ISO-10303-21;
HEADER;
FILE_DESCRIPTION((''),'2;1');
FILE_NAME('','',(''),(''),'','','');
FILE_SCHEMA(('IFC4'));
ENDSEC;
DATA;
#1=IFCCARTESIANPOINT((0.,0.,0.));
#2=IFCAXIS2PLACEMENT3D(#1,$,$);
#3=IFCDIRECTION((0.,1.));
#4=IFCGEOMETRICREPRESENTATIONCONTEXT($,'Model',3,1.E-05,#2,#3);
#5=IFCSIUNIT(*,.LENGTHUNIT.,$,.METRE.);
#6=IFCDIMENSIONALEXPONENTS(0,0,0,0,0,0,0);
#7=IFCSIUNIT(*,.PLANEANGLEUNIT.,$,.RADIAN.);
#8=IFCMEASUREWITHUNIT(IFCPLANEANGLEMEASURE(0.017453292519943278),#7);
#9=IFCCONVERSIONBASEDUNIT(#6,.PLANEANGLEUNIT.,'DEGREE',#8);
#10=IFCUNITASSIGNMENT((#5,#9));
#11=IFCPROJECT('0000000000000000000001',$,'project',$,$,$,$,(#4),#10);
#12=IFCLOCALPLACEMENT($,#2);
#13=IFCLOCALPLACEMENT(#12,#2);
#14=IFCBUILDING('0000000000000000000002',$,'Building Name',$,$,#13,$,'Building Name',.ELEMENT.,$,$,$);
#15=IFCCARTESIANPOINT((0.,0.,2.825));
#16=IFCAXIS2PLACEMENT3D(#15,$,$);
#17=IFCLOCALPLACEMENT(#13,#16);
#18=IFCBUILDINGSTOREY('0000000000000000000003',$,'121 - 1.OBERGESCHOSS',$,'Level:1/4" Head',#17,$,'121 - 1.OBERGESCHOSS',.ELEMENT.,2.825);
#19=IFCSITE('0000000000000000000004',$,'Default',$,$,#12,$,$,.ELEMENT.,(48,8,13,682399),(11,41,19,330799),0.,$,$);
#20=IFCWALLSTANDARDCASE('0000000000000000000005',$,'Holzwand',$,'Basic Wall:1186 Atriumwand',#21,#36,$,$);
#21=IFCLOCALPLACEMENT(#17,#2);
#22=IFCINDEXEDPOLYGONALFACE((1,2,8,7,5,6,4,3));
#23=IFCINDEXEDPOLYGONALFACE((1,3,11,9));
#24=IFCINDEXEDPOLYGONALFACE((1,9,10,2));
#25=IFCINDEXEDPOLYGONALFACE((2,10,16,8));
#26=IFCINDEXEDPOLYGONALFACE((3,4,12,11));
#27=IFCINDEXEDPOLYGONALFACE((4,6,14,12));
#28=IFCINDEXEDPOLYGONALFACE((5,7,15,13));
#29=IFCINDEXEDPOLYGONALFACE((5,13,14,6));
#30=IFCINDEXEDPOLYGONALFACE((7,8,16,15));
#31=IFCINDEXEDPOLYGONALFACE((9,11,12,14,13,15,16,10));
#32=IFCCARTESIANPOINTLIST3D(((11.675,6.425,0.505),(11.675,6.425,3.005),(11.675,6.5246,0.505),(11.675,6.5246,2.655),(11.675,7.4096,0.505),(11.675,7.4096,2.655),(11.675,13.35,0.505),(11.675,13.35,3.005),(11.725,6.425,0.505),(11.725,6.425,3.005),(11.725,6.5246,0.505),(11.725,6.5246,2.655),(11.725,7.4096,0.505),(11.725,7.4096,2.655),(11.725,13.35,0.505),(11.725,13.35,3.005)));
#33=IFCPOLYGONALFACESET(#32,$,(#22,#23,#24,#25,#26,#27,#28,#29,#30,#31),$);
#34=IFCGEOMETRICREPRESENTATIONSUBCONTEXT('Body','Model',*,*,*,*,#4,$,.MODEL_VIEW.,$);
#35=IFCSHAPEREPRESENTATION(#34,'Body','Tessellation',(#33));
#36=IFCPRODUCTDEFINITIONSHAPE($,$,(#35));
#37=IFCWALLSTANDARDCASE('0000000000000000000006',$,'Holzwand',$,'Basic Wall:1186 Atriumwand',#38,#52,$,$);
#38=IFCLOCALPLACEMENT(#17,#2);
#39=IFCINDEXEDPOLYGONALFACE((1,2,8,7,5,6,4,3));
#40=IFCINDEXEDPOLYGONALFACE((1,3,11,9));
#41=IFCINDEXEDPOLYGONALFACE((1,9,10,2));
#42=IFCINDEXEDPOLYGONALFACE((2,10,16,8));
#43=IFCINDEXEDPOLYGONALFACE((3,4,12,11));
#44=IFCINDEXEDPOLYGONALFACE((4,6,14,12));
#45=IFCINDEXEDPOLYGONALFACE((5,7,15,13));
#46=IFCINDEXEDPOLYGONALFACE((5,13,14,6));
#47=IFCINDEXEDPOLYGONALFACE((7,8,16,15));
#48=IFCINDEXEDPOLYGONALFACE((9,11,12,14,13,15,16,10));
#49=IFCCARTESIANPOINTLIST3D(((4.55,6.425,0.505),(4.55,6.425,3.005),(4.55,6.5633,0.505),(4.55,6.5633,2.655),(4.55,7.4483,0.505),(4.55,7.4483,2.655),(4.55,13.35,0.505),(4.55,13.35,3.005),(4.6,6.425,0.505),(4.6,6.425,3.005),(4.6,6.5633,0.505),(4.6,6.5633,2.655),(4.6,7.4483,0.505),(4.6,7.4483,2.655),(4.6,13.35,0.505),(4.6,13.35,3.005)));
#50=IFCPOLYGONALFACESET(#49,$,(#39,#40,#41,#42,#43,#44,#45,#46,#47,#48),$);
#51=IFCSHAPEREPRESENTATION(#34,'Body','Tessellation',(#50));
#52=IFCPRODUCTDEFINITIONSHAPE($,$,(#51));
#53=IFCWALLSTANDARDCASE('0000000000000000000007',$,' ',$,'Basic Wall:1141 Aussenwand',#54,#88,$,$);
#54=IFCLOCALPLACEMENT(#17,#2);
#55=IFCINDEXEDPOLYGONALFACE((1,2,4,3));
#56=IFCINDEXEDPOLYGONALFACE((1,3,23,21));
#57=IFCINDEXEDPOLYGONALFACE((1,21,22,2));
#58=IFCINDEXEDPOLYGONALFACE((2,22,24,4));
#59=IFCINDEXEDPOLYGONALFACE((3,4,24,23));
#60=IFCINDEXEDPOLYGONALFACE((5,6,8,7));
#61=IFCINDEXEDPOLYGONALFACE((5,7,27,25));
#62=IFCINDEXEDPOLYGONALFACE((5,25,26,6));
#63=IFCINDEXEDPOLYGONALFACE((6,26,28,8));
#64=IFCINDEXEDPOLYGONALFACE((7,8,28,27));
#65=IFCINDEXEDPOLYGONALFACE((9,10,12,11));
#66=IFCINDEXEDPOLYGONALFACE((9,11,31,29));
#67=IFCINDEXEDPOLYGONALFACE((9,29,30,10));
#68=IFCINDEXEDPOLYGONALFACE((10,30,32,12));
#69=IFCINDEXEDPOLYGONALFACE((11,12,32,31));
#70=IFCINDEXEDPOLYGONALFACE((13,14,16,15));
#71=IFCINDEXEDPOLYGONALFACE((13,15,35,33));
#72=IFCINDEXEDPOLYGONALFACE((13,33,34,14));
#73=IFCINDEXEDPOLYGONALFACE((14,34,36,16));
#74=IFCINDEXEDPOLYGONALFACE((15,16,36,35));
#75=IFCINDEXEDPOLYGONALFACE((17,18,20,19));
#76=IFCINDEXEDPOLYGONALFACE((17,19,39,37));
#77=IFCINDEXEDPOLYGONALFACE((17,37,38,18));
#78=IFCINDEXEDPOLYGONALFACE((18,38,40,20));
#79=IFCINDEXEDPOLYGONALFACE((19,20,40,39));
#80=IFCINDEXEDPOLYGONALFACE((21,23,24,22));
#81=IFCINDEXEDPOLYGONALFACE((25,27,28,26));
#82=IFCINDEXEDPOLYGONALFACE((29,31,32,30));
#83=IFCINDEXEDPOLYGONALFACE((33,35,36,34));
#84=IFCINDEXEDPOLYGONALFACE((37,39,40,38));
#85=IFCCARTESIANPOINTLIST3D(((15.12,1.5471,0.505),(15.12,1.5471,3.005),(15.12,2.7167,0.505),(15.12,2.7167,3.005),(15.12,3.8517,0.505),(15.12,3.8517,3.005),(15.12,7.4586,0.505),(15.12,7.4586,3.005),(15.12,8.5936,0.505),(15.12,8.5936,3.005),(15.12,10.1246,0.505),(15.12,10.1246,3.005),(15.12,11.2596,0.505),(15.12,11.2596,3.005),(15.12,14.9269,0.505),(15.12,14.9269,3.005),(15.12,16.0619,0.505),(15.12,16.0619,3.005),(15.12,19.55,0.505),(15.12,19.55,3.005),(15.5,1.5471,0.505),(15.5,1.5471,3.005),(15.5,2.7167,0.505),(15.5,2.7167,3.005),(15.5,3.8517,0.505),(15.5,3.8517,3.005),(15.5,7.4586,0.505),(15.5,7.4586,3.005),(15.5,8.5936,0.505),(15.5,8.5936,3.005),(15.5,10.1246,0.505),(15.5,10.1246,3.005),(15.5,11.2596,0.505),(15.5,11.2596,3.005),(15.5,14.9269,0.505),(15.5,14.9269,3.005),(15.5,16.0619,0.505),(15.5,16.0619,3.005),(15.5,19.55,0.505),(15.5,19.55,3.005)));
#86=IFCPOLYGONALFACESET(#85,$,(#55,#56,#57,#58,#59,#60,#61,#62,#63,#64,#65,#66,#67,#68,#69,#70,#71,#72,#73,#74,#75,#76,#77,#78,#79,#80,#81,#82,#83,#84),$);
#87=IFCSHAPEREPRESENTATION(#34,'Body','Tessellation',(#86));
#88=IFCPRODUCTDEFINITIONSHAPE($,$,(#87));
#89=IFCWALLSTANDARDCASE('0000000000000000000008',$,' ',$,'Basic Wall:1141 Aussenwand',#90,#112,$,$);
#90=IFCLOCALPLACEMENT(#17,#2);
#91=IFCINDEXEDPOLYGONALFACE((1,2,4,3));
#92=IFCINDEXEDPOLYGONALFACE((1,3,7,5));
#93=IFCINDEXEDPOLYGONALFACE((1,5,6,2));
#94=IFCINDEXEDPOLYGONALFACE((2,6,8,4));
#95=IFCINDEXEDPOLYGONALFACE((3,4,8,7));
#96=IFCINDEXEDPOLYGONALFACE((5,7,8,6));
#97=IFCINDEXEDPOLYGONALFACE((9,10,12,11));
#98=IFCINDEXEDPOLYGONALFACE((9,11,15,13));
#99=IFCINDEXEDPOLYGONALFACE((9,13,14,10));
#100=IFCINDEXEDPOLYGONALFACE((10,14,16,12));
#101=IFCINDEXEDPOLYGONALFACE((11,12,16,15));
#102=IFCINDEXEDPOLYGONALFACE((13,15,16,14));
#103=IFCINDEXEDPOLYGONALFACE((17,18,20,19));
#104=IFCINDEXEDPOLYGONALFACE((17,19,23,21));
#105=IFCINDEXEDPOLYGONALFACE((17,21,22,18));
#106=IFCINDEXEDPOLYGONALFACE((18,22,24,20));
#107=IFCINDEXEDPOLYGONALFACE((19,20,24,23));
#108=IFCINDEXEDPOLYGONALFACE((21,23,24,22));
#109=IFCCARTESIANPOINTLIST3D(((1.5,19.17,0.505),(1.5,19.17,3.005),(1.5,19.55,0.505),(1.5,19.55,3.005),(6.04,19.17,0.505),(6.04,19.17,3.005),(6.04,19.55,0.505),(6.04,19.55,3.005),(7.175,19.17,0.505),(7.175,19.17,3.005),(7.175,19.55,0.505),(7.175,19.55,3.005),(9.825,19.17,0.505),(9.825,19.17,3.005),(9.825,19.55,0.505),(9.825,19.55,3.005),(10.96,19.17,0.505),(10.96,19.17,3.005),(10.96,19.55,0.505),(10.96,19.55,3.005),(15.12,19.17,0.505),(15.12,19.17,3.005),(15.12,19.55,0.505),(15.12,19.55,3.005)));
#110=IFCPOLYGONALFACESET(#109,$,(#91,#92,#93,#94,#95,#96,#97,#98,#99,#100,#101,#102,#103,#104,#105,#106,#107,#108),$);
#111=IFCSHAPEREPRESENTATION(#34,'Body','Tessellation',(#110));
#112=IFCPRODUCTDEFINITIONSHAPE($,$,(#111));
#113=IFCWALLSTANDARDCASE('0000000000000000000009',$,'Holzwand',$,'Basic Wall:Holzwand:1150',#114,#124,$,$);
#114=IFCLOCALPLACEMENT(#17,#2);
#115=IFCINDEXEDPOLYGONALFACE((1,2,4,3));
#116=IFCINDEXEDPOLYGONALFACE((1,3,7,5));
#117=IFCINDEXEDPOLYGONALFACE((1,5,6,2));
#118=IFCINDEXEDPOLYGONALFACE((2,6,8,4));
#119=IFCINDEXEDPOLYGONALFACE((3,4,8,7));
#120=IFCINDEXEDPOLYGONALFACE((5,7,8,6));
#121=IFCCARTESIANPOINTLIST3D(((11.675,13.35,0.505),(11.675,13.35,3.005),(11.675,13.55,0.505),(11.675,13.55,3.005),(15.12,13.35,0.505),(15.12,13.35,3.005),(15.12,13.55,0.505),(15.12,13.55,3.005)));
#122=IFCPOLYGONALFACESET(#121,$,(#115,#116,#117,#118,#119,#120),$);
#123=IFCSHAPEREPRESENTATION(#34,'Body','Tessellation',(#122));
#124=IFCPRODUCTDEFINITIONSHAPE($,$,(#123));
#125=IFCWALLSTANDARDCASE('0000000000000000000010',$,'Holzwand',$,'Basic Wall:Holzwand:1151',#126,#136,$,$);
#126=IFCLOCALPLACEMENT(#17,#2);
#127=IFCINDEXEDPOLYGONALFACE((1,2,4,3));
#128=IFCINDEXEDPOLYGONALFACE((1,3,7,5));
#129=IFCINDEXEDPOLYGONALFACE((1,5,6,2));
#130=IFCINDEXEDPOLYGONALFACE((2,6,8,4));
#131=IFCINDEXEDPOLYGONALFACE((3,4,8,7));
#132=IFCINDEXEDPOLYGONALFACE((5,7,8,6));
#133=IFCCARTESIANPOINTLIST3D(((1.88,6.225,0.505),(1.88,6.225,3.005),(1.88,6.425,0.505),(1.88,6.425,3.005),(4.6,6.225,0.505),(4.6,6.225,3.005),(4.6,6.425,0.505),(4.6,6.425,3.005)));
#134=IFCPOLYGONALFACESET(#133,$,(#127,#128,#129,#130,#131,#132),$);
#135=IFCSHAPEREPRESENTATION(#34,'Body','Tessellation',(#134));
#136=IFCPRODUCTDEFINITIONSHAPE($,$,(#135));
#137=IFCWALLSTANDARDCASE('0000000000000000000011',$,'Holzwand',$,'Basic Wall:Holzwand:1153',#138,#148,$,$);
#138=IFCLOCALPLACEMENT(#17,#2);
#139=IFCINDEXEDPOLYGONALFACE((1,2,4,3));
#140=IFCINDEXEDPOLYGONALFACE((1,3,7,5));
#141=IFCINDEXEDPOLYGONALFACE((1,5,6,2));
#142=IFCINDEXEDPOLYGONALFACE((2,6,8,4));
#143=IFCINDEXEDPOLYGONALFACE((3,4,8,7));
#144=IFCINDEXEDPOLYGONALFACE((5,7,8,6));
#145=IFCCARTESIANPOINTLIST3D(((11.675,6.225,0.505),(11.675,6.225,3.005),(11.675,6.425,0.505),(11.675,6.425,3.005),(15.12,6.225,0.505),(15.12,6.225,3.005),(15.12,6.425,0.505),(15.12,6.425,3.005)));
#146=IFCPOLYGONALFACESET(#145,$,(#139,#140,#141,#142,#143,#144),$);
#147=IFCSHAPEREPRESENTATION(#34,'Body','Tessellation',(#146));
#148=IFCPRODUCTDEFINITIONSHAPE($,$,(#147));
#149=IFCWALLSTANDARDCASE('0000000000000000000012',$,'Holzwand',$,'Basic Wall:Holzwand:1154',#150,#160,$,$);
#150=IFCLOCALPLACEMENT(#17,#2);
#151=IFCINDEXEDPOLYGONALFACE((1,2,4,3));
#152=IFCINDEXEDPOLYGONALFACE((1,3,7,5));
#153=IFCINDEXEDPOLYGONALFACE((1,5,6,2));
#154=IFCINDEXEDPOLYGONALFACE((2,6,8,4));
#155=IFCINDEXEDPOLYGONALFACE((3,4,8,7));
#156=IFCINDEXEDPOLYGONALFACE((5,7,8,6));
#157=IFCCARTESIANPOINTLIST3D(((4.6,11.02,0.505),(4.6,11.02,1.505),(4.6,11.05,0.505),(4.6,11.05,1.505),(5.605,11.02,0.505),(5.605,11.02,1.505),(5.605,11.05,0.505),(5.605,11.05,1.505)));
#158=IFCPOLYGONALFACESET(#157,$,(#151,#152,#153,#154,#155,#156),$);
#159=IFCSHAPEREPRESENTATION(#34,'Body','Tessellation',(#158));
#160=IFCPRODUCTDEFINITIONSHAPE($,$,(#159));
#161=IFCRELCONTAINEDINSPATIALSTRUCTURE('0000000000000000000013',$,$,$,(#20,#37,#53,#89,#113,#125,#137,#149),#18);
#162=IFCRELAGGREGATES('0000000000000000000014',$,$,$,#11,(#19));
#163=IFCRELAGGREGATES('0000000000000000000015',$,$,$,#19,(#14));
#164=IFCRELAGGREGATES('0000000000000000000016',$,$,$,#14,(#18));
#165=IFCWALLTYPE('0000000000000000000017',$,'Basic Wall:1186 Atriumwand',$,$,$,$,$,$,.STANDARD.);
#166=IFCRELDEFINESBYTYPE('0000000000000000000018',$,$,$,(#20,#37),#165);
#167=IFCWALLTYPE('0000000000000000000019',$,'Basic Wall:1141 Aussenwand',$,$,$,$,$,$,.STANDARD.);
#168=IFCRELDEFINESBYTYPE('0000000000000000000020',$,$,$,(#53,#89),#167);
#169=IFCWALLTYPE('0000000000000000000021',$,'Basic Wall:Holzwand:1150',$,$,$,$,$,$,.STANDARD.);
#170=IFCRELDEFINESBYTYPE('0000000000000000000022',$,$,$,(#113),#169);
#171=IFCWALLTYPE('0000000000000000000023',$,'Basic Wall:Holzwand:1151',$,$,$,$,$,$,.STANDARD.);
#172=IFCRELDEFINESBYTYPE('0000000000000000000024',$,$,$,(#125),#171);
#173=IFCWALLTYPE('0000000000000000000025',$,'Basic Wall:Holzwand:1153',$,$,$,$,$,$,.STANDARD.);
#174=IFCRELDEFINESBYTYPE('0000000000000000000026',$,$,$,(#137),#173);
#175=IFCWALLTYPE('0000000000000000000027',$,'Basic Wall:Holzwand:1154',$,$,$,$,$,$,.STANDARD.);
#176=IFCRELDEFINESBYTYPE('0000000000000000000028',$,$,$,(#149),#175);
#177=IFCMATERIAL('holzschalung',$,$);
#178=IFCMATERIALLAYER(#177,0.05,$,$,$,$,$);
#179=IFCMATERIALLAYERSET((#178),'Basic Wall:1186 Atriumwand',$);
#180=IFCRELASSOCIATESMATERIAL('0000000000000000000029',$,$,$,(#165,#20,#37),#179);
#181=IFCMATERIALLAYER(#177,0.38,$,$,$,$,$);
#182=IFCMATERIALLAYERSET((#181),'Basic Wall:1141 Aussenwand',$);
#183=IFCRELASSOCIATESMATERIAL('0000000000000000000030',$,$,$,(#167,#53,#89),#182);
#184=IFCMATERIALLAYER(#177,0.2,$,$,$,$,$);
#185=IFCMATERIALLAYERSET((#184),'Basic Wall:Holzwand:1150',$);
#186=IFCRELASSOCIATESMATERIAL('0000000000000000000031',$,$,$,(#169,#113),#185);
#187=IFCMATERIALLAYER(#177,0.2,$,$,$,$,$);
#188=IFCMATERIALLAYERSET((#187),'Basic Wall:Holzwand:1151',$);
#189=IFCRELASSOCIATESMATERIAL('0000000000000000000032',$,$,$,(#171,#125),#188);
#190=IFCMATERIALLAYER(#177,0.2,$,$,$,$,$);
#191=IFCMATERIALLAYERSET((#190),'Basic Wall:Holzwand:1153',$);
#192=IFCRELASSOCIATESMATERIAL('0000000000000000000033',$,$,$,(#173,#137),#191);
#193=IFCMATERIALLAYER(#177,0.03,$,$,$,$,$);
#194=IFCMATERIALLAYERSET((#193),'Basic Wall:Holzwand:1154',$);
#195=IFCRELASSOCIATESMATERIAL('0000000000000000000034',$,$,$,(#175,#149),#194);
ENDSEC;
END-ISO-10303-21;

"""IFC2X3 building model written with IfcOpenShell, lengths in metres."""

from ifc_helpers import new_model, entity, si_unit, converted_unit, direction, frame, frame_2d, origin, place, context, subcontext, project, spatial, rectangle, extrude, material, layer, layer_set, layer_usage, type_object, element, save


model = new_model("IFC2X3")

# Units and contexts
model_context = context("Model", 3, precision=1e-05, world=origin(), true_north=direction((0.0, 1.0)))
body_context = subcontext(model_context, "Body", "Model", "MODEL_VIEW")
ifc_project = project(units=[si_unit("LENGTHUNIT", "METRE"), converted_unit("PLANEANGLEUNIT", "DEGREE", entity("IfcPlaneAngleMeasure", 0.017453292519943278), si_unit("PLANEANGLEUNIT", "RADIAN"), dimensions=[0, 0, 0, 0, 0, 0, 0])], contexts=[model_context])

# Site, building, storey
site_placement = place(None, origin())
site = spatial("IfcSite", under=ifc_project, at=site_placement, Name="Default", CompositionType="ELEMENT", RefLatitude=(48, 8, 13, 682399), RefLongitude=(11, 41, 19, 330799), RefElevation=0.0)
building_placement = place(site_placement, origin())
building = spatial("IfcBuilding", under=site, at=building_placement, Name="Building Name", LongName="Building Name", CompositionType="ELEMENT")
storey_placement = place(building_placement, frame((0.0, 0.0, 2.825)))
storey = spatial("IfcBuildingStorey", under=building, at=storey_placement, Name="121 - 1.OBERGESCHOSS", ObjectType="Level:1/4\" Head", LongName="121 - 1.OBERGESCHOSS", CompositionType="ELEMENT", Elevation=2.825)

# Walls, openings
ifc_material = material(Name="holzschalung")
ifc_layer_1 = layer(ifc_material, 0.05)
ifc_layer_set_1 = layer_set([ifc_layer_1], Name="Basic Wall:1186 Atriumwand")
ifc_layer_usage_1 = layer_usage(ifc_layer_set_1, "AXIS2", "NEGATIVE", 0.025)
wall_type_1 = type_object("IfcWallType", Name="Basic Wall:1186 Atriumwand", PredefinedType="STANDARD", material=ifc_layer_set_1)
wall_1_placement = place(storey_placement, frame((11.7, 6.425, 0.505), z_axis=(0.0, 0.0, 1.0), x_axis=(0.0, 1.0, 0.0)))
wall_1 = element("IfcWallStandardCase", 1, at=wall_1_placement, inside=storey, type_object=wall_type_1, material=ifc_layer_usage_1, Name="Holzwand", ObjectType="Basic Wall:1186 Atriumwand", context=body_context, shape_type="SweptSolid", body=[
    extrude(rectangle(XDim=6.925, YDim=0.05, at=frame_2d((3.4625, 0.0), x_axis=(-1.0, 0.0))), origin(), (0.0, 0.0, 1.0), 2.5),
])
opening_1_placement = place(wall_1_placement, frame((-6.425, 11.7, -0.505), z_axis=(0.0, 0.0, 1.0), x_axis=(0.0, -1.0, 0.0)))
element("IfcOpeningElement", 2, at=opening_1_placement, cuts=wall_1, ObjectType="Opening", context=body_context, shape_type="SweptSolid", body=[
    extrude(rectangle(XDim=2.3, YDim=0.885, at=frame_2d((0.0, 0.0), x_axis=(0.0, 1.0))), frame((11.802, 6.9671, 1.505), z_axis=(-1.0, 0.0, 0.0), x_axis=(0.0, -1.0, 0.0)), (0.0, 0.0, 1.0), 0.204),
])
ifc_layer_usage_2 = layer_usage(ifc_layer_set_1, "AXIS2", "NEGATIVE", 0.025)
wall_2_placement = place(storey_placement, frame((4.575, 13.35, 0.505), z_axis=(0.0, 0.0, 1.0), x_axis=(0.0, -1.0, 0.0)))
wall_2 = element("IfcWallStandardCase", 3, at=wall_2_placement, inside=storey, type_object=wall_type_1, material=ifc_layer_usage_2, Name="Holzwand", ObjectType="Basic Wall:1186 Atriumwand", context=body_context, shape_type="SweptSolid", body=[
    extrude(rectangle(XDim=6.925, YDim=0.05, at=frame_2d((3.4625, 0.0), x_axis=(-1.0, 0.0))), origin(), (0.0, 0.0, 1.0), 2.5),
])
opening_2_placement = place(wall_2_placement, frame((13.35, -4.575, -0.505), z_axis=(0.0, 0.0, 1.0), x_axis=(0.0, 1.0, 0.0)))
element("IfcOpeningElement", 4, at=opening_2_placement, cuts=wall_2, ObjectType="Opening", context=body_context, shape_type="SweptSolid", body=[
    extrude(rectangle(XDim=2.3, YDim=0.885, at=frame_2d((0.0, 0.0), x_axis=(0.0, 1.0))), frame((4.473, 7.0058, 1.505), z_axis=(1.0, 0.0, 0.0), x_axis=(0.0, 1.0, 0.0)), (0.0, 0.0, 1.0), 0.204),
])

# Walls, openings
ifc_layer_2 = layer(ifc_material, 0.38)
ifc_layer_set_2 = layer_set([ifc_layer_2], Name="Basic Wall:1141 Aussenwand")
ifc_layer_usage_3 = layer_usage(ifc_layer_set_2, "AXIS2", "NEGATIVE", 0.19)
wall_type_2 = type_object("IfcWallType", Name="Basic Wall:1141 Aussenwand", PredefinedType="STANDARD", material=ifc_layer_set_2)
wall_3_placement = place(storey_placement, frame((15.31, 19.55, 0.505), z_axis=(0.0, 0.0, 1.0), x_axis=(0.0, -1.0, 0.0)))
wall_3 = element("IfcWallStandardCase", 5, at=wall_3_placement, inside=storey, type_object=wall_type_2, material=ifc_layer_usage_3, Name=" ", ObjectType="Basic Wall:1141 Aussenwand", context=body_context, shape_type="SweptSolid", body=[
    extrude(rectangle(XDim=18.0029, YDim=0.38, at=frame_2d((9.0014, 0.0), x_axis=(-1.0, 0.0))), origin(), (0.0, 0.0, 1.0), 2.5),
])
opening_3_placement = place(wall_3_placement, origin())
element("IfcOpeningElement", 6, at=opening_3_placement, cuts=wall_3, ObjectType="Opening", context=body_context, shape_type="SweptSolid", body=[
    extrude(rectangle(XDim=2.5, YDim=1.135, at=frame_2d((0.0, 0.0), x_axis=(1.0, 0.0))), frame((4.0556, -0.19, 1.25), z_axis=(0.0, 1.0, 0.0), x_axis=(0.0, 0.0, 1.0)), (0.0, 0.0, 1.0), 0.38),
])
opening_4_placement = place(wall_3_placement, origin())
element("IfcOpeningElement", 7, at=opening_4_placement, cuts=wall_3, ObjectType="Opening", context=body_context, shape_type="SweptSolid", body=[
    extrude(rectangle(XDim=2.5, YDim=1.135, at=frame_2d((0.0, 0.0), x_axis=(1.0, 0.0))), frame((8.8579, -0.19, 1.25), z_axis=(0.0, 1.0, 0.0), x_axis=(0.0, 0.0, 1.0)), (0.0, 0.0, 1.0), 0.38),
])
opening_5_placement = place(wall_3_placement, origin())
element("IfcOpeningElement", 8, at=opening_5_placement, cuts=wall_3, ObjectType="Opening", context=body_context, shape_type="SweptSolid", body=[
    extrude(rectangle(XDim=2.5, YDim=1.135, at=frame_2d((0.0, 0.0), x_axis=(1.0, 0.0))), frame((11.5239, -0.19, 1.25), z_axis=(0.0, 1.0, 0.0), x_axis=(0.0, 0.0, 1.0)), (0.0, 0.0, 1.0), 0.38),
])
opening_6_placement = place(wall_3_placement, origin())
element("IfcOpeningElement", 9, at=opening_6_placement, cuts=wall_3, ObjectType="Opening", context=body_context, shape_type="SweptSolid", body=[
    extrude(rectangle(XDim=2.5, YDim=1.135, at=frame_2d((0.0, 0.0), x_axis=(1.0, 0.0))), frame((16.2658, -0.19, 1.25), z_axis=(0.0, 1.0, 0.0), x_axis=(0.0, 0.0, 1.0)), (0.0, 0.0, 1.0), 0.38),
])
ifc_layer_usage_4 = layer_usage(ifc_layer_set_2, "AXIS2", "NEGATIVE", 0.19)
wall_4_placement = place(storey_placement, frame((1.5, 19.36, 0.505)))
wall_4 = element("IfcWallStandardCase", 10, at=wall_4_placement, inside=storey, type_object=wall_type_2, material=ifc_layer_usage_4, Name=" ", ObjectType="Basic Wall:1141 Aussenwand", context=body_context, shape_type="SweptSolid", body=[
    extrude(rectangle(XDim=13.62, YDim=0.38, at=frame_2d((6.81, 0.0), x_axis=(-1.0, 0.0))), origin(), (0.0, 0.0, 1.0), 2.5),
])
opening_7_placement = place(wall_4_placement, origin())
element("IfcOpeningElement", 11, at=opening_7_placement, cuts=wall_4, ObjectType="Opening", context=body_context, shape_type="SweptSolid", body=[
    extrude(rectangle(XDim=2.5, YDim=1.135, at=frame_2d((0.0, 0.0), x_axis=(1.0, 0.0))), frame((8.8925, -0.19, 1.25), z_axis=(0.0, 1.0, 0.0), x_axis=(0.0, 0.0, 1.0)), (0.0, 0.0, 1.0), 0.38),
])
opening_8_placement = place(wall_4_placement, origin())
element("IfcOpeningElement", 12, at=opening_8_placement, cuts=wall_4, ObjectType="Opening", context=body_context, shape_type="SweptSolid", body=[
    extrude(rectangle(XDim=2.5, YDim=1.135, at=frame_2d((0.0, 0.0), x_axis=(1.0, 0.0))), frame((5.1075, -0.19, 1.25), z_axis=(0.0, 1.0, 0.0), x_axis=(0.0, 0.0, 1.0)), (0.0, 0.0, 1.0), 0.38),
])

# Walls
ifc_layer_3 = layer(ifc_material, 0.2)
ifc_layer_set_3 = layer_set([ifc_layer_3], Name="Basic Wall:Holzwand:1150")
ifc_layer_usage_5 = layer_usage(ifc_layer_set_3, "AXIS2", "NEGATIVE", 0.1)
wall_type_3 = type_object("IfcWallType", Name="Basic Wall:Holzwand:1150", PredefinedType="STANDARD", material=ifc_layer_set_3)
wall_5_placement = place(storey_placement, frame((11.675, 13.45, 0.505)))
element("IfcWallStandardCase", 13, at=wall_5_placement, inside=storey, type_object=wall_type_3, material=ifc_layer_usage_5, Name="Holzwand", ObjectType="Basic Wall:Holzwand:1150", context=body_context, shape_type="SweptSolid", body=[
    extrude(rectangle(XDim=3.445, YDim=0.2, at=frame_2d((1.7225, 0.0), x_axis=(-1.0, 0.0))), origin(), (0.0, 0.0, 1.0), 2.5),
])
ifc_layer_4 = layer(ifc_material, 0.2)
ifc_layer_set_4 = layer_set([ifc_layer_4], Name="Basic Wall:Holzwand:1151")
ifc_layer_usage_6 = layer_usage(ifc_layer_set_4, "AXIS2", "NEGATIVE", 0.1)
wall_type_4 = type_object("IfcWallType", Name="Basic Wall:Holzwand:1151", PredefinedType="STANDARD", material=ifc_layer_set_4)
wall_6_placement = place(storey_placement, frame((4.6, 6.325, 0.505), z_axis=(0.0, 0.0, 1.0), x_axis=(-1.0, 0.0, 0.0)))
element("IfcWallStandardCase", 14, at=wall_6_placement, inside=storey, type_object=wall_type_4, material=ifc_layer_usage_6, Name="Holzwand", ObjectType="Basic Wall:Holzwand:1151", context=body_context, shape_type="SweptSolid", body=[
    extrude(rectangle(XDim=2.72, YDim=0.2, at=frame_2d((1.36, 0.0), x_axis=(-1.0, 0.0))), origin(), (0.0, 0.0, 1.0), 2.5),
])
ifc_layer_5 = layer(ifc_material, 0.2)
ifc_layer_set_5 = layer_set([ifc_layer_5], Name="Basic Wall:Holzwand:1153")
ifc_layer_usage_7 = layer_usage(ifc_layer_set_5, "AXIS2", "NEGATIVE", 0.1)
wall_type_5 = type_object("IfcWallType", Name="Basic Wall:Holzwand:1153", PredefinedType="STANDARD", material=ifc_layer_set_5)
wall_7_placement = place(storey_placement, frame((15.12, 6.325, 0.505), z_axis=(0.0, 0.0, 1.0), x_axis=(-1.0, 0.0, 0.0)))
element("IfcWallStandardCase", 15, at=wall_7_placement, inside=storey, type_object=wall_type_5, material=ifc_layer_usage_7, Name="Holzwand", ObjectType="Basic Wall:Holzwand:1153", context=body_context, shape_type="SweptSolid", body=[
    extrude(rectangle(XDim=3.445, YDim=0.2, at=frame_2d((1.7225, 0.0), x_axis=(-1.0, 0.0))), origin(), (0.0, 0.0, 1.0), 2.5),
])
ifc_layer_6 = layer(ifc_material, 0.03)
ifc_layer_set_6 = layer_set([ifc_layer_6], Name="Basic Wall:Holzwand:1154")
ifc_layer_usage_8 = layer_usage(ifc_layer_set_6, "AXIS2", "NEGATIVE", 0.015)
wall_type_6 = type_object("IfcWallType", Name="Basic Wall:Holzwand:1154", PredefinedType="STANDARD", material=ifc_layer_set_6)
wall_8_placement = place(storey_placement, frame((5.605, 11.035, 0.505), z_axis=(0.0, 0.0, 1.0), x_axis=(-1.0, 0.0, 0.0)))
element("IfcWallStandardCase", 16, at=wall_8_placement, inside=storey, type_object=wall_type_6, material=ifc_layer_usage_8, Name="Holzwand", ObjectType="Basic Wall:Holzwand:1154", context=body_context, shape_type="SweptSolid", body=[
    extrude(rectangle(XDim=1.005, YDim=0.03, at=frame_2d((0.5025, 0.0), x_axis=(-1.0, 0.0))), origin(), (0.0, 0.0, 1.0), 1.0),
])

save(model, "model.ifc")
